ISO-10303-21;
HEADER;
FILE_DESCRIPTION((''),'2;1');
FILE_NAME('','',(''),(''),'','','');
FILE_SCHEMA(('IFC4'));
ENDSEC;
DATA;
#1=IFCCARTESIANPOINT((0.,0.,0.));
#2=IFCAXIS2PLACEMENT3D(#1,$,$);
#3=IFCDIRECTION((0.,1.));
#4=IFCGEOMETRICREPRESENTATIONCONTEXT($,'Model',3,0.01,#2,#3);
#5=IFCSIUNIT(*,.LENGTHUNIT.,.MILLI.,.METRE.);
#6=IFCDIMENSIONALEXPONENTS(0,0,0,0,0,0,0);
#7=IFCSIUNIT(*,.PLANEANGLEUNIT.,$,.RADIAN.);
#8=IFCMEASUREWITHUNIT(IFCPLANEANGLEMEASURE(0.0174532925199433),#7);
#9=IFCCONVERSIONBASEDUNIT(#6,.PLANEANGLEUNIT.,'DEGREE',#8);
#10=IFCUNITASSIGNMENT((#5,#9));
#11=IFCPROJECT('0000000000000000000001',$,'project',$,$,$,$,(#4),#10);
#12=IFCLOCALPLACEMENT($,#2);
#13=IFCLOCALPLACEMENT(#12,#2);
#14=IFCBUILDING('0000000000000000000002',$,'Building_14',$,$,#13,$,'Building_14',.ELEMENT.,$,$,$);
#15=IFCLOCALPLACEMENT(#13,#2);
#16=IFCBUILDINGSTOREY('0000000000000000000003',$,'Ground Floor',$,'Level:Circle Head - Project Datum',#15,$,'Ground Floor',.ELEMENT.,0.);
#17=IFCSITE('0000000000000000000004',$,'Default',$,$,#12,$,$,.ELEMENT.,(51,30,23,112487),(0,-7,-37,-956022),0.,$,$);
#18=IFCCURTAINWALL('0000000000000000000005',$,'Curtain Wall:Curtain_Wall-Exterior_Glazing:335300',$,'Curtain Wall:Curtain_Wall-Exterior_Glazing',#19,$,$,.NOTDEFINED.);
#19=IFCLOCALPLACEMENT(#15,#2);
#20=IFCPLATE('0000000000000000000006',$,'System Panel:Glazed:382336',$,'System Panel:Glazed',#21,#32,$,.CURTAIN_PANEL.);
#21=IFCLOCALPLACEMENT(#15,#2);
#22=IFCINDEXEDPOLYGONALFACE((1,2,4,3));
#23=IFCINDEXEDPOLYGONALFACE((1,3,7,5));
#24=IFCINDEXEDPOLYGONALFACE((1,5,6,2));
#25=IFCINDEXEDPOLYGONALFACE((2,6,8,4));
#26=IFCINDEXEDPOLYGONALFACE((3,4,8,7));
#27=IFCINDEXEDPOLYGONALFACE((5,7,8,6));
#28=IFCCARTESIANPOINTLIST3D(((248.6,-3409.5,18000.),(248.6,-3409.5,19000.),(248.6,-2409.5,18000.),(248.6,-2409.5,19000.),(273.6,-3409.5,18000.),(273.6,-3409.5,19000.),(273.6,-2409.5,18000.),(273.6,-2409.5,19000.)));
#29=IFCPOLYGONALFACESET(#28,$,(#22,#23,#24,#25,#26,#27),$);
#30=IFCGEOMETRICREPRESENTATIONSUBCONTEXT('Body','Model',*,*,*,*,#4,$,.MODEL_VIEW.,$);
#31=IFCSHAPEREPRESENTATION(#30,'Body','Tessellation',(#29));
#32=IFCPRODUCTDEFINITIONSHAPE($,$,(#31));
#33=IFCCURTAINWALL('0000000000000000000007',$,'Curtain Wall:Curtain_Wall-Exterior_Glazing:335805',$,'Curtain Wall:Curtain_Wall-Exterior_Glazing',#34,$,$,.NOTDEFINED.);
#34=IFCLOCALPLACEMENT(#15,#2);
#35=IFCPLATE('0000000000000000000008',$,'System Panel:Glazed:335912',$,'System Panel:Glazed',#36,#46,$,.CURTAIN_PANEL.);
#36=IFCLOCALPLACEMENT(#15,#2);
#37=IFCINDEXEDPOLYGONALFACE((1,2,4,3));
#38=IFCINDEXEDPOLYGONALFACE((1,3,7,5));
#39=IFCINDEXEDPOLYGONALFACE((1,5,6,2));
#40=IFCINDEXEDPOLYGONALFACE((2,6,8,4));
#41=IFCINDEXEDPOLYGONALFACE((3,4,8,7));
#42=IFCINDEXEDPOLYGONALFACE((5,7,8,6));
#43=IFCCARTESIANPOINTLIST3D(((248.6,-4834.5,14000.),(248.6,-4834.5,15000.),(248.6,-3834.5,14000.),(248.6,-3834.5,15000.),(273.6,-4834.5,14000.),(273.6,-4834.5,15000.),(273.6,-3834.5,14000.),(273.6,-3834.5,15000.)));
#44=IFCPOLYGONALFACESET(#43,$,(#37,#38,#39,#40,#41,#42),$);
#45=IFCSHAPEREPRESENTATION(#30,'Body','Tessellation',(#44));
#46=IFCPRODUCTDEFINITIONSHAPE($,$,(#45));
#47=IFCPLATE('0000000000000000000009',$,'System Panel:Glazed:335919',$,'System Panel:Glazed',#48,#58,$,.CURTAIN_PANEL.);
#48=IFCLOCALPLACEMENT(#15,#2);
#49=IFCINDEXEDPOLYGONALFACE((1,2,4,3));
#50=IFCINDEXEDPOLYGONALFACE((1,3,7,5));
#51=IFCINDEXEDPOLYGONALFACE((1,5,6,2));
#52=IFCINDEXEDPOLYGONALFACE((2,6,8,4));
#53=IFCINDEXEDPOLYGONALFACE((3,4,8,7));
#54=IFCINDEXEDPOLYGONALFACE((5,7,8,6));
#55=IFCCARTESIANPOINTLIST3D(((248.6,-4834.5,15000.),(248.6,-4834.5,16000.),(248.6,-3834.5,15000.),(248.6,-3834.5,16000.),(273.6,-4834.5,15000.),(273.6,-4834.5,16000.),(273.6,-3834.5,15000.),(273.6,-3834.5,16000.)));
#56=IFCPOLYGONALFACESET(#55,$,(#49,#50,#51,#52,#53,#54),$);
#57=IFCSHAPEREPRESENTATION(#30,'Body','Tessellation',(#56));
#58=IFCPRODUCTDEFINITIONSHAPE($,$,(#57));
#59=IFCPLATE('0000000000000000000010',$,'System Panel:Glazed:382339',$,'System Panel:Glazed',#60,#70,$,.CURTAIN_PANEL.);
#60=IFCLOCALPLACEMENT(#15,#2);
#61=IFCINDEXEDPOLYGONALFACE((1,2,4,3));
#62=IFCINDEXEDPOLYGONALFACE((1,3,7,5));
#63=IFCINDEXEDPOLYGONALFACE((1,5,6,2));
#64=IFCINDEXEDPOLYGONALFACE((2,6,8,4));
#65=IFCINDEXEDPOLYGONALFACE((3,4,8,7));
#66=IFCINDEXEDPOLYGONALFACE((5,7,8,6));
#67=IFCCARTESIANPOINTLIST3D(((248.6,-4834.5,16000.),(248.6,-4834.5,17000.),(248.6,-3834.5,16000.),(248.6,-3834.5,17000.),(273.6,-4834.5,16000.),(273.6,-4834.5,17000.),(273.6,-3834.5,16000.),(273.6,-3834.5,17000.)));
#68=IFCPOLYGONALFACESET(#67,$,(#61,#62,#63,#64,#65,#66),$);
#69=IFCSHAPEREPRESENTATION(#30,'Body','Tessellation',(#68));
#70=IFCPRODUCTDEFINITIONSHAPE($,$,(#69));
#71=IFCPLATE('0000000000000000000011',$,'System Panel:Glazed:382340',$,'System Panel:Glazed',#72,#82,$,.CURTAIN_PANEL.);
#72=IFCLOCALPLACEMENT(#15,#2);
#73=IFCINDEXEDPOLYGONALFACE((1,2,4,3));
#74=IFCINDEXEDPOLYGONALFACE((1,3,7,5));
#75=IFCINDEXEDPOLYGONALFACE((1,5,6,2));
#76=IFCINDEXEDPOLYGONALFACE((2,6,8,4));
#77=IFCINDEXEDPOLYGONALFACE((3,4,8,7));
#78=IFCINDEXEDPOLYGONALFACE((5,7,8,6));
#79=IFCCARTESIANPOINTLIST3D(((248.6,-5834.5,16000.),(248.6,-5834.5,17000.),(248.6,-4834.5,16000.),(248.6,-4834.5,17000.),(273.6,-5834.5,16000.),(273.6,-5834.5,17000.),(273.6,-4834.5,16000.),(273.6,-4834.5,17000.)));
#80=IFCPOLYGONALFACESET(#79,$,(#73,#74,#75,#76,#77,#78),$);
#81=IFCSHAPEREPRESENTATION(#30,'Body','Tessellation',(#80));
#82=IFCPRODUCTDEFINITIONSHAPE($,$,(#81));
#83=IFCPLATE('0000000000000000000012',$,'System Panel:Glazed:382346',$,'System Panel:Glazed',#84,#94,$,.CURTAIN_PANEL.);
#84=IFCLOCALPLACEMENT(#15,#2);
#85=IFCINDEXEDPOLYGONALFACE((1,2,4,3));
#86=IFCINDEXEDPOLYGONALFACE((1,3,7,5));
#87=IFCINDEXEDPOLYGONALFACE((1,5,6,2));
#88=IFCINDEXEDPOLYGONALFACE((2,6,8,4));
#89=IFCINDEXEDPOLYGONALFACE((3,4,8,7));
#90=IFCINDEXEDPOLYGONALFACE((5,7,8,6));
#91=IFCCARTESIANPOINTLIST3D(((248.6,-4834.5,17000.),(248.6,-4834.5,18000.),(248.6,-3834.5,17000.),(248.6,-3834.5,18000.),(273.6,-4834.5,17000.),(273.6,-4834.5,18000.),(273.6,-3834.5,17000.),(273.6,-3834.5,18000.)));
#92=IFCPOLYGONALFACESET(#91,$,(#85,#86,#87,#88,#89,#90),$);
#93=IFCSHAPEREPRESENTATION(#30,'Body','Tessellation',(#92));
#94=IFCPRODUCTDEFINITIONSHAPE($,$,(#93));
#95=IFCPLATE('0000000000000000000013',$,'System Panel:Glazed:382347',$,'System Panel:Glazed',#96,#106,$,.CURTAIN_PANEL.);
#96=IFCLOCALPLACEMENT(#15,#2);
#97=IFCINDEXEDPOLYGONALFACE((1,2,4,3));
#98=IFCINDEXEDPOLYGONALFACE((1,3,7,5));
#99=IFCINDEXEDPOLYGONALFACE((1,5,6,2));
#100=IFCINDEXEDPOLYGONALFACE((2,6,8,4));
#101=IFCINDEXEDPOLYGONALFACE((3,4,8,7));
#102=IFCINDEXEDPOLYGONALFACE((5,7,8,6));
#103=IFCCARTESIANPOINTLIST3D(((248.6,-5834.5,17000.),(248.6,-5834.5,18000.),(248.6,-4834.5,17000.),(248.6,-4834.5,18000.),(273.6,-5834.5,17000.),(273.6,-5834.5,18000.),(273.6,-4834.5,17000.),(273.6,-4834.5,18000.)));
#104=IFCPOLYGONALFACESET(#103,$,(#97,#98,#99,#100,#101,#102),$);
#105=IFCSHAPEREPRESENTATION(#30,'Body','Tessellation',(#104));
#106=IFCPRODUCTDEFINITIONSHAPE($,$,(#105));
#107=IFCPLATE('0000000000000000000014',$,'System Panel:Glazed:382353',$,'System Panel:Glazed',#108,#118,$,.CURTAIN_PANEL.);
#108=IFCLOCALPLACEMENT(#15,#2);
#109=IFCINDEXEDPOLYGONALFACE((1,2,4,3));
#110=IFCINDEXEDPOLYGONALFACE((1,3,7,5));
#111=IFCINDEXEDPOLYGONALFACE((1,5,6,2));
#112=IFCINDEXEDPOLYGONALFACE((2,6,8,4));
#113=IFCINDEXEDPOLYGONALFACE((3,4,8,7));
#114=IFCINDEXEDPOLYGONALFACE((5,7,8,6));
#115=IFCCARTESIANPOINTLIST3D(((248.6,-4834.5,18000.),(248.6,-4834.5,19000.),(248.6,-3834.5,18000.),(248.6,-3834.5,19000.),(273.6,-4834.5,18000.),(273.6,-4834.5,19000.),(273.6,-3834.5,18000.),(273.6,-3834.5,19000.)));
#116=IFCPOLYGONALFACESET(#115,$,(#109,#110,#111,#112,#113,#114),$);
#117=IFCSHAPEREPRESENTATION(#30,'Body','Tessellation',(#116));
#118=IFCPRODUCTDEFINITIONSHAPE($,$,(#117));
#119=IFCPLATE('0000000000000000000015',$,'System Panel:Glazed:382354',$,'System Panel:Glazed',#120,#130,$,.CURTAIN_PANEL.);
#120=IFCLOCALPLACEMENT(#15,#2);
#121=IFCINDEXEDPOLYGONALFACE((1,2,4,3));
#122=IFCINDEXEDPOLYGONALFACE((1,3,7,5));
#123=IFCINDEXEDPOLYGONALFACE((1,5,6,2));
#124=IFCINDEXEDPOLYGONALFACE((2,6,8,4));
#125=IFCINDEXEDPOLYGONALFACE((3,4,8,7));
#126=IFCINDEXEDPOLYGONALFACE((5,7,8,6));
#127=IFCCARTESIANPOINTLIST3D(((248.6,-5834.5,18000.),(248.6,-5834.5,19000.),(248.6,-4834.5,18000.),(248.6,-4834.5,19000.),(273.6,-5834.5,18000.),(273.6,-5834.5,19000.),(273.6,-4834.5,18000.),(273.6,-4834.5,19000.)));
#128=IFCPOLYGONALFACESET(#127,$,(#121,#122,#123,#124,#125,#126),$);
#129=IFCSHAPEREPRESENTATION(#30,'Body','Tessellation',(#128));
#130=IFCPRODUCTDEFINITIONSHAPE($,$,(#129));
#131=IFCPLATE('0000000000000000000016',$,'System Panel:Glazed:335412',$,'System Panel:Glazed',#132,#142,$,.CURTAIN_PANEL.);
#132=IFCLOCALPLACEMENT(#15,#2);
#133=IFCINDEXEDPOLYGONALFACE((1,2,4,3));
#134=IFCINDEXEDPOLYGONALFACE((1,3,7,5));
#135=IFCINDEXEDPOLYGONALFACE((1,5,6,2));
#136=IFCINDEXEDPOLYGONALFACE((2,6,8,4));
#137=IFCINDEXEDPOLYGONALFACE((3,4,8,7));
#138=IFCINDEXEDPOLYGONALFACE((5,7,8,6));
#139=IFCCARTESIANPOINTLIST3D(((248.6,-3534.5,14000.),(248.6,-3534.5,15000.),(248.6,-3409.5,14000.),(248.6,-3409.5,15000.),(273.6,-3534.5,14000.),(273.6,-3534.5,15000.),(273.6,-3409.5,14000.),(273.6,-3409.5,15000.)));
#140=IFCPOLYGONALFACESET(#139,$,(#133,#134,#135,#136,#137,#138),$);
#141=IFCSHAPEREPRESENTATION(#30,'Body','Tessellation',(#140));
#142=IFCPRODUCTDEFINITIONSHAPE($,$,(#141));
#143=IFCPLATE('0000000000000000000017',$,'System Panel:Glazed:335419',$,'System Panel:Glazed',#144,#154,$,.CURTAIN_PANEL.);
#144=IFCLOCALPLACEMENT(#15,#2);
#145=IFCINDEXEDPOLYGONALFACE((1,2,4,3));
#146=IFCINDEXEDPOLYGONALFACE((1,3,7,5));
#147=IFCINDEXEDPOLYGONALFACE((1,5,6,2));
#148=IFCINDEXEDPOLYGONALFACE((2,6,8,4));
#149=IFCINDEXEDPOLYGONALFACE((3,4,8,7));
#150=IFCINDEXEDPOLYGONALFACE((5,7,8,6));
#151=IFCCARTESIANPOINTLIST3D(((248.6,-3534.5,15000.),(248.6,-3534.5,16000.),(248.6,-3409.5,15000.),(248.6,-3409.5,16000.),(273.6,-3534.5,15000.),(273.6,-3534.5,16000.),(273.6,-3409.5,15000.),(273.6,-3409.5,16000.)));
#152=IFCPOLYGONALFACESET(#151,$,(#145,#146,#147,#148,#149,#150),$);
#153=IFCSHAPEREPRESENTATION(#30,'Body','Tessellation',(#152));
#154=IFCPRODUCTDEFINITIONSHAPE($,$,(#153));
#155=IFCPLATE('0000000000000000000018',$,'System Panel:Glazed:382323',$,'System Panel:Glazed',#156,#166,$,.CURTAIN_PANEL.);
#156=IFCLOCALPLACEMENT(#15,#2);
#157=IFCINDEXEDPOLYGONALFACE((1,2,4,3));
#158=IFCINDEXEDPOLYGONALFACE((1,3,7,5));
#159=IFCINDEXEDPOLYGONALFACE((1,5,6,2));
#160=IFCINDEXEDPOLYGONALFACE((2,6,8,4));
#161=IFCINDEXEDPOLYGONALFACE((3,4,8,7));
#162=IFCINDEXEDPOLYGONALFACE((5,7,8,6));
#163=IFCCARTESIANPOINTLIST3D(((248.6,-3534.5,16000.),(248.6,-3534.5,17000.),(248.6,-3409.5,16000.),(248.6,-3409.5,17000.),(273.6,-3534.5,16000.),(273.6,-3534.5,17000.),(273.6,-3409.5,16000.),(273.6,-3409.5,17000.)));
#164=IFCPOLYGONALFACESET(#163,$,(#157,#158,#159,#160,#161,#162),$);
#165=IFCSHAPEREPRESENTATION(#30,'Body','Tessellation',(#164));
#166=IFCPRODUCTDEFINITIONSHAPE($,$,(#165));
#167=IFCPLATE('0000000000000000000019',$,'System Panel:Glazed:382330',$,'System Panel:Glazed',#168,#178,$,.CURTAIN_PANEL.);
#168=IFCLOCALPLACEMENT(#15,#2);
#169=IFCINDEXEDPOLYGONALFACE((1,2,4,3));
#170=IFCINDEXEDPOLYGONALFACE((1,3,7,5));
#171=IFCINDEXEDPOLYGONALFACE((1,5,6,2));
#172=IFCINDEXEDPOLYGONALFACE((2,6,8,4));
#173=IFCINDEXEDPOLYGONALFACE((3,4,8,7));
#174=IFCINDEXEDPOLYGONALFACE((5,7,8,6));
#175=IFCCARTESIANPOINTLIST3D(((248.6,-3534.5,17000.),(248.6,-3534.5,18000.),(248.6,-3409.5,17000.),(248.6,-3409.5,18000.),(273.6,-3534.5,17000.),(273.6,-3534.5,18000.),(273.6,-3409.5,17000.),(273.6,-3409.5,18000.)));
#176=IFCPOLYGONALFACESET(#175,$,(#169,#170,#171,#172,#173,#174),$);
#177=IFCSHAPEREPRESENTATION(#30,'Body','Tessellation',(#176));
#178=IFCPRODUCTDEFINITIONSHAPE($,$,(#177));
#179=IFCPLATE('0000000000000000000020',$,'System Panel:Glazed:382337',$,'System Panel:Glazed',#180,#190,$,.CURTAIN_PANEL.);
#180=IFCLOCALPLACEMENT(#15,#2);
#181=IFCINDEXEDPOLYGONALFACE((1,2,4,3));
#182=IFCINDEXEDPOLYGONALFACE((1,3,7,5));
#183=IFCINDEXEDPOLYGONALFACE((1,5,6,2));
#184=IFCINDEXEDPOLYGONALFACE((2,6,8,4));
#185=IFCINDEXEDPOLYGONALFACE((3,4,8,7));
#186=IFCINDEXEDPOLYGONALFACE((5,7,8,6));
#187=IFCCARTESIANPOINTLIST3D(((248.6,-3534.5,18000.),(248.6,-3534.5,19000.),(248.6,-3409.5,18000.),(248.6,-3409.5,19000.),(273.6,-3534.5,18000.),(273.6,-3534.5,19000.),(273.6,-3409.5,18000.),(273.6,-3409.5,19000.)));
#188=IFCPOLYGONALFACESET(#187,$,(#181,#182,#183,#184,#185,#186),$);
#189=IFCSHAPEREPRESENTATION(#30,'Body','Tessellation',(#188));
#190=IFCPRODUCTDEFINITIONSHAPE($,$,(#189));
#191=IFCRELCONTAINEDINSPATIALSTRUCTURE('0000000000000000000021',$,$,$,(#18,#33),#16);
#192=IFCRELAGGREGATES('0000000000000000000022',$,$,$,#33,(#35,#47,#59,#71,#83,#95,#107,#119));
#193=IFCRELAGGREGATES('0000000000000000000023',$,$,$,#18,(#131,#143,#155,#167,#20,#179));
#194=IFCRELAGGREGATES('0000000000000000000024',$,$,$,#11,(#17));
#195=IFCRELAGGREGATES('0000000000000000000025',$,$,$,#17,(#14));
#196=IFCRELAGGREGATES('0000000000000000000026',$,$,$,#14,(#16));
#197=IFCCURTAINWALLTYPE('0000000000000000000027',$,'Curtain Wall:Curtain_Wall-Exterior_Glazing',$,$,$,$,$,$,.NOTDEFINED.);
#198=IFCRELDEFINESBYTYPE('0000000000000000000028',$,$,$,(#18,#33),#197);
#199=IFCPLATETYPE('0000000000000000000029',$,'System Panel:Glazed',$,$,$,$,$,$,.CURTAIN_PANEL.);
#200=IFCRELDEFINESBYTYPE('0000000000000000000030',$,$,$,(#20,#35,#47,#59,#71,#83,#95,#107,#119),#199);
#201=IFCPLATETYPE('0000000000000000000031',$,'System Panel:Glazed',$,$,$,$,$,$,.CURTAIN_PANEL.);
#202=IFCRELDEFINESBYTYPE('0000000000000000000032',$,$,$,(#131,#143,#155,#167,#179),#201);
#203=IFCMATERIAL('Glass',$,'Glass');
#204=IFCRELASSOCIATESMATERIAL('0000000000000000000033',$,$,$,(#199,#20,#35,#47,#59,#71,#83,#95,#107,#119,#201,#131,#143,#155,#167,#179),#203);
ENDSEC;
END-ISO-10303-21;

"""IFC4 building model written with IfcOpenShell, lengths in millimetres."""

from ifc_helpers import new_model, entity, si_unit, converted_unit, direction, frame, origin, place, context, subcontext, project, spatial, indexed_curve, outline, extrude, source, transform, mapped, material, type_object, type_shapes, element, aggregate, save


model = new_model("IFC4")

# Units and contexts
model_context = context("Model", 3, precision=0.01, world=origin(), true_north=direction((0.0, 1.0)))
body_context = subcontext(model_context, "Body", "Model", "MODEL_VIEW")
ifc_project = project(units=[si_unit("LENGTHUNIT", "METRE", prefix="MILLI"), converted_unit("PLANEANGLEUNIT", "DEGREE", entity("IfcPlaneAngleMeasure", 0.0174532925199433), si_unit("PLANEANGLEUNIT", "RADIAN"), dimensions=[0, 0, 0, 0, 0, 0, 0])], contexts=[model_context])

# Site, building, storey
site_placement = place(None, origin())
site = spatial("IfcSite", under=ifc_project, at=site_placement, Name="Default", CompositionType="ELEMENT", RefLatitude=(51, 30, 23, 112487), RefLongitude=(0, -7, -37, -956022), RefElevation=0.0)
building_placement = place(site_placement, origin())
building = spatial("IfcBuilding", under=site, at=building_placement, Name="Building_14", LongName="Building_14", CompositionType="ELEMENT")
storey_placement = place(building_placement, origin())
storey = spatial("IfcBuildingStorey", under=building, at=storey_placement, Name="Ground Floor", ObjectType="Level:Circle Head - Project Datum", LongName="Ground Floor", CompositionType="ELEMENT", Elevation=0.0)

# Curtain walls, plates
curtain_wall_type = type_object("IfcCurtainWallType", Name="Curtain Wall:Curtain_Wall-Exterior_Glazing", PredefinedType="NOTDEFINED")
ifc_material = material(Name="Glass", Category="Glass")
plate_type_1 = type_object("IfcPlateType", Name="System Panel:Glazed", PredefinedType="CURTAIN_PANEL", material=ifc_material)
shared_shape_1 = source(origin(), body_context, "Body", "SweptSolid", [
    extrude(outline(indexed_curve([(-12.5, -500.0), (12.5, -500.0), (12.5, 500.0), (-12.5, 500.0), (-12.5, -500.0)], self_intersect=False)), frame((0.0, -37.0, 0.0), z_axis=(0.0, 0.0, 1.0), x_axis=(0.0, 1.0, 0.0)), (0.0, 0.0, 1.0), 1000.0),
])
type_shapes(plate_type_1, [shared_shape_1])
curtain_wall_1_placement = place(storey_placement, origin())
curtain_wall_1 = element("IfcCurtainWall", 1, at=curtain_wall_1_placement, inside=storey, type_object=curtain_wall_type, Name="Curtain Wall:Curtain_Wall-Exterior_Glazing:335300", ObjectType="Curtain Wall:Curtain_Wall-Exterior_Glazing", PredefinedType="NOTDEFINED")
plate_1_placement = place(curtain_wall_1_placement, frame((298.1, -2909.5, 18000.0), z_axis=(0.0, 0.0, 1.0), x_axis=(0.0, -1.0, 0.0)))
plate_1 = element("IfcPlate", 2, at=plate_1_placement, type_object=plate_type_1, material=ifc_material, Name="System Panel:Glazed:382336", ObjectType="System Panel:Glazed", PredefinedType="CURTAIN_PANEL", context=body_context, shape_type="MappedRepresentation", body=[
    mapped(shared_shape_1, transform((0.0, 0.0, 0.0), scale=1.0)),
])
curtain_wall_2_placement = place(storey_placement, origin())
curtain_wall_2 = element("IfcCurtainWall", 3, at=curtain_wall_2_placement, inside=storey, type_object=curtain_wall_type, Name="Curtain Wall:Curtain_Wall-Exterior_Glazing:335805", ObjectType="Curtain Wall:Curtain_Wall-Exterior_Glazing", PredefinedType="NOTDEFINED")
plate_2_placement = place(curtain_wall_2_placement, frame((298.1, -4334.5, 14000.0), z_axis=(0.0, 0.0, 1.0), x_axis=(0.0, -1.0, 0.0)))
plate_2 = element("IfcPlate", 4, at=plate_2_placement, type_object=plate_type_1, material=ifc_material, Name="System Panel:Glazed:335912", ObjectType="System Panel:Glazed", PredefinedType="CURTAIN_PANEL", context=body_context, shape_type="MappedRepresentation", body=[
    mapped(shared_shape_1, transform((0.0, 0.0, 0.0), scale=1.0)),
])
plate_3_placement = place(curtain_wall_2_placement, frame((298.1, -4334.5, 15000.0), z_axis=(0.0, 0.0, 1.0), x_axis=(0.0, -1.0, 0.0)))
plate_3 = element("IfcPlate", 5, at=plate_3_placement, type_object=plate_type_1, material=ifc_material, Name="System Panel:Glazed:335919", ObjectType="System Panel:Glazed", PredefinedType="CURTAIN_PANEL", context=body_context, shape_type="MappedRepresentation", body=[
    mapped(shared_shape_1, transform((0.0, 0.0, 0.0), scale=1.0)),
])
plate_4_placement = place(curtain_wall_2_placement, frame((298.1, -4334.5, 16000.0), z_axis=(0.0, 0.0, 1.0), x_axis=(0.0, -1.0, 0.0)))
plate_4 = element("IfcPlate", 6, at=plate_4_placement, type_object=plate_type_1, material=ifc_material, Name="System Panel:Glazed:382339", ObjectType="System Panel:Glazed", PredefinedType="CURTAIN_PANEL", context=body_context, shape_type="MappedRepresentation", body=[
    mapped(shared_shape_1, transform((0.0, 0.0, 0.0), scale=1.0)),
])
plate_5_placement = place(curtain_wall_2_placement, frame((298.1, -5334.5, 16000.0), z_axis=(0.0, 0.0, 1.0), x_axis=(0.0, -1.0, 0.0)))
plate_5 = element("IfcPlate", 7, at=plate_5_placement, type_object=plate_type_1, material=ifc_material, Name="System Panel:Glazed:382340", ObjectType="System Panel:Glazed", PredefinedType="CURTAIN_PANEL", context=body_context, shape_type="MappedRepresentation", body=[
    mapped(shared_shape_1, transform((0.0, 0.0, 0.0), scale=1.0)),
])
plate_6_placement = place(curtain_wall_2_placement, frame((298.1, -4334.5, 17000.0), z_axis=(0.0, 0.0, 1.0), x_axis=(0.0, -1.0, 0.0)))
plate_6 = element("IfcPlate", 8, at=plate_6_placement, type_object=plate_type_1, material=ifc_material, Name="System Panel:Glazed:382346", ObjectType="System Panel:Glazed", PredefinedType="CURTAIN_PANEL", context=body_context, shape_type="MappedRepresentation", body=[
    mapped(shared_shape_1, transform((0.0, 0.0, 0.0), scale=1.0)),
])
plate_7_placement = place(curtain_wall_2_placement, frame((298.1, -5334.5, 17000.0), z_axis=(0.0, 0.0, 1.0), x_axis=(0.0, -1.0, 0.0)))
plate_7 = element("IfcPlate", 9, at=plate_7_placement, type_object=plate_type_1, material=ifc_material, Name="System Panel:Glazed:382347", ObjectType="System Panel:Glazed", PredefinedType="CURTAIN_PANEL", context=body_context, shape_type="MappedRepresentation", body=[
    mapped(shared_shape_1, transform((0.0, 0.0, 0.0), scale=1.0)),
])
plate_8_placement = place(curtain_wall_2_placement, frame((298.1, -4334.5, 18000.0), z_axis=(0.0, 0.0, 1.0), x_axis=(0.0, -1.0, 0.0)))
plate_8 = element("IfcPlate", 10, at=plate_8_placement, type_object=plate_type_1, material=ifc_material, Name="System Panel:Glazed:382353", ObjectType="System Panel:Glazed", PredefinedType="CURTAIN_PANEL", context=body_context, shape_type="MappedRepresentation", body=[
    mapped(shared_shape_1, transform((0.0, 0.0, 0.0), scale=1.0)),
])
plate_9_placement = place(curtain_wall_2_placement, frame((298.1, -5334.5, 18000.0), z_axis=(0.0, 0.0, 1.0), x_axis=(0.0, -1.0, 0.0)))
plate_9 = element("IfcPlate", 11, at=plate_9_placement, type_object=plate_type_1, material=ifc_material, Name="System Panel:Glazed:382354", ObjectType="System Panel:Glazed", PredefinedType="CURTAIN_PANEL", context=body_context, shape_type="MappedRepresentation", body=[
    mapped(shared_shape_1, transform((0.0, 0.0, 0.0), scale=1.0)),
])
aggregate(curtain_wall_2, [plate_2, plate_3, plate_4, plate_5, plate_6, plate_7, plate_8, plate_9])

# Plates
plate_type_2 = type_object("IfcPlateType", Name="System Panel:Glazed", PredefinedType="CURTAIN_PANEL", material=ifc_material)
shared_shape_2 = source(origin(), body_context, "Body", "SweptSolid", [
    extrude(outline(indexed_curve([(-12.5, -62.5), (12.5, -62.5), (12.5, 62.5), (-12.5, 62.5), (-12.5, -62.5)], self_intersect=False)), frame((0.0, -37.0, 0.0), z_axis=(0.0, 0.0, 1.0), x_axis=(0.0, 1.0, 0.0)), (0.0, 0.0, 1.0), 1000.0),
])
type_shapes(plate_type_2, [shared_shape_2])
plate_10_placement = place(curtain_wall_1_placement, frame((298.1, -3472.0, 14000.0), z_axis=(0.0, 0.0, 1.0), x_axis=(0.0, -1.0, 0.0)))
plate_10 = element("IfcPlate", 12, at=plate_10_placement, type_object=plate_type_2, material=ifc_material, Name="System Panel:Glazed:335412", ObjectType="System Panel:Glazed", PredefinedType="CURTAIN_PANEL", context=body_context, shape_type="MappedRepresentation", body=[
    mapped(shared_shape_2, transform((0.0, 0.0, 0.0), scale=1.0)),
])
plate_11_placement = place(curtain_wall_1_placement, frame((298.1, -3472.0, 15000.0), z_axis=(0.0, 0.0, 1.0), x_axis=(0.0, -1.0, 0.0)))
plate_11 = element("IfcPlate", 13, at=plate_11_placement, type_object=plate_type_2, material=ifc_material, Name="System Panel:Glazed:335419", ObjectType="System Panel:Glazed", PredefinedType="CURTAIN_PANEL", context=body_context, shape_type="MappedRepresentation", body=[
    mapped(shared_shape_2, transform((0.0, 0.0, 0.0), scale=1.0)),
])
plate_12_placement = place(curtain_wall_1_placement, frame((298.1, -3472.0, 16000.0), z_axis=(0.0, 0.0, 1.0), x_axis=(0.0, -1.0, 0.0)))
plate_12 = element("IfcPlate", 14, at=plate_12_placement, type_object=plate_type_2, material=ifc_material, Name="System Panel:Glazed:382323", ObjectType="System Panel:Glazed", PredefinedType="CURTAIN_PANEL", context=body_context, shape_type="MappedRepresentation", body=[
    mapped(shared_shape_2, transform((0.0, 0.0, 0.0), scale=1.0)),
])
plate_13_placement = place(curtain_wall_1_placement, frame((298.1, -3472.0, 17000.0), z_axis=(0.0, 0.0, 1.0), x_axis=(0.0, -1.0, 0.0)))
plate_13 = element("IfcPlate", 15, at=plate_13_placement, type_object=plate_type_2, material=ifc_material, Name="System Panel:Glazed:382330", ObjectType="System Panel:Glazed", PredefinedType="CURTAIN_PANEL", context=body_context, shape_type="MappedRepresentation", body=[
    mapped(shared_shape_2, transform((0.0, 0.0, 0.0), scale=1.0)),
])
plate_14_placement = place(curtain_wall_1_placement, frame((298.1, -3472.0, 18000.0), z_axis=(0.0, 0.0, 1.0), x_axis=(0.0, -1.0, 0.0)))
plate_14 = element("IfcPlate", 16, at=plate_14_placement, type_object=plate_type_2, material=ifc_material, Name="System Panel:Glazed:382337", ObjectType="System Panel:Glazed", PredefinedType="CURTAIN_PANEL", context=body_context, shape_type="MappedRepresentation", body=[
    mapped(shared_shape_2, transform((0.0, 0.0, 0.0), scale=1.0)),
])
aggregate(curtain_wall_1, [plate_10, plate_11, plate_12, plate_13, plate_1, plate_14])

save(model, "model.ifc")
